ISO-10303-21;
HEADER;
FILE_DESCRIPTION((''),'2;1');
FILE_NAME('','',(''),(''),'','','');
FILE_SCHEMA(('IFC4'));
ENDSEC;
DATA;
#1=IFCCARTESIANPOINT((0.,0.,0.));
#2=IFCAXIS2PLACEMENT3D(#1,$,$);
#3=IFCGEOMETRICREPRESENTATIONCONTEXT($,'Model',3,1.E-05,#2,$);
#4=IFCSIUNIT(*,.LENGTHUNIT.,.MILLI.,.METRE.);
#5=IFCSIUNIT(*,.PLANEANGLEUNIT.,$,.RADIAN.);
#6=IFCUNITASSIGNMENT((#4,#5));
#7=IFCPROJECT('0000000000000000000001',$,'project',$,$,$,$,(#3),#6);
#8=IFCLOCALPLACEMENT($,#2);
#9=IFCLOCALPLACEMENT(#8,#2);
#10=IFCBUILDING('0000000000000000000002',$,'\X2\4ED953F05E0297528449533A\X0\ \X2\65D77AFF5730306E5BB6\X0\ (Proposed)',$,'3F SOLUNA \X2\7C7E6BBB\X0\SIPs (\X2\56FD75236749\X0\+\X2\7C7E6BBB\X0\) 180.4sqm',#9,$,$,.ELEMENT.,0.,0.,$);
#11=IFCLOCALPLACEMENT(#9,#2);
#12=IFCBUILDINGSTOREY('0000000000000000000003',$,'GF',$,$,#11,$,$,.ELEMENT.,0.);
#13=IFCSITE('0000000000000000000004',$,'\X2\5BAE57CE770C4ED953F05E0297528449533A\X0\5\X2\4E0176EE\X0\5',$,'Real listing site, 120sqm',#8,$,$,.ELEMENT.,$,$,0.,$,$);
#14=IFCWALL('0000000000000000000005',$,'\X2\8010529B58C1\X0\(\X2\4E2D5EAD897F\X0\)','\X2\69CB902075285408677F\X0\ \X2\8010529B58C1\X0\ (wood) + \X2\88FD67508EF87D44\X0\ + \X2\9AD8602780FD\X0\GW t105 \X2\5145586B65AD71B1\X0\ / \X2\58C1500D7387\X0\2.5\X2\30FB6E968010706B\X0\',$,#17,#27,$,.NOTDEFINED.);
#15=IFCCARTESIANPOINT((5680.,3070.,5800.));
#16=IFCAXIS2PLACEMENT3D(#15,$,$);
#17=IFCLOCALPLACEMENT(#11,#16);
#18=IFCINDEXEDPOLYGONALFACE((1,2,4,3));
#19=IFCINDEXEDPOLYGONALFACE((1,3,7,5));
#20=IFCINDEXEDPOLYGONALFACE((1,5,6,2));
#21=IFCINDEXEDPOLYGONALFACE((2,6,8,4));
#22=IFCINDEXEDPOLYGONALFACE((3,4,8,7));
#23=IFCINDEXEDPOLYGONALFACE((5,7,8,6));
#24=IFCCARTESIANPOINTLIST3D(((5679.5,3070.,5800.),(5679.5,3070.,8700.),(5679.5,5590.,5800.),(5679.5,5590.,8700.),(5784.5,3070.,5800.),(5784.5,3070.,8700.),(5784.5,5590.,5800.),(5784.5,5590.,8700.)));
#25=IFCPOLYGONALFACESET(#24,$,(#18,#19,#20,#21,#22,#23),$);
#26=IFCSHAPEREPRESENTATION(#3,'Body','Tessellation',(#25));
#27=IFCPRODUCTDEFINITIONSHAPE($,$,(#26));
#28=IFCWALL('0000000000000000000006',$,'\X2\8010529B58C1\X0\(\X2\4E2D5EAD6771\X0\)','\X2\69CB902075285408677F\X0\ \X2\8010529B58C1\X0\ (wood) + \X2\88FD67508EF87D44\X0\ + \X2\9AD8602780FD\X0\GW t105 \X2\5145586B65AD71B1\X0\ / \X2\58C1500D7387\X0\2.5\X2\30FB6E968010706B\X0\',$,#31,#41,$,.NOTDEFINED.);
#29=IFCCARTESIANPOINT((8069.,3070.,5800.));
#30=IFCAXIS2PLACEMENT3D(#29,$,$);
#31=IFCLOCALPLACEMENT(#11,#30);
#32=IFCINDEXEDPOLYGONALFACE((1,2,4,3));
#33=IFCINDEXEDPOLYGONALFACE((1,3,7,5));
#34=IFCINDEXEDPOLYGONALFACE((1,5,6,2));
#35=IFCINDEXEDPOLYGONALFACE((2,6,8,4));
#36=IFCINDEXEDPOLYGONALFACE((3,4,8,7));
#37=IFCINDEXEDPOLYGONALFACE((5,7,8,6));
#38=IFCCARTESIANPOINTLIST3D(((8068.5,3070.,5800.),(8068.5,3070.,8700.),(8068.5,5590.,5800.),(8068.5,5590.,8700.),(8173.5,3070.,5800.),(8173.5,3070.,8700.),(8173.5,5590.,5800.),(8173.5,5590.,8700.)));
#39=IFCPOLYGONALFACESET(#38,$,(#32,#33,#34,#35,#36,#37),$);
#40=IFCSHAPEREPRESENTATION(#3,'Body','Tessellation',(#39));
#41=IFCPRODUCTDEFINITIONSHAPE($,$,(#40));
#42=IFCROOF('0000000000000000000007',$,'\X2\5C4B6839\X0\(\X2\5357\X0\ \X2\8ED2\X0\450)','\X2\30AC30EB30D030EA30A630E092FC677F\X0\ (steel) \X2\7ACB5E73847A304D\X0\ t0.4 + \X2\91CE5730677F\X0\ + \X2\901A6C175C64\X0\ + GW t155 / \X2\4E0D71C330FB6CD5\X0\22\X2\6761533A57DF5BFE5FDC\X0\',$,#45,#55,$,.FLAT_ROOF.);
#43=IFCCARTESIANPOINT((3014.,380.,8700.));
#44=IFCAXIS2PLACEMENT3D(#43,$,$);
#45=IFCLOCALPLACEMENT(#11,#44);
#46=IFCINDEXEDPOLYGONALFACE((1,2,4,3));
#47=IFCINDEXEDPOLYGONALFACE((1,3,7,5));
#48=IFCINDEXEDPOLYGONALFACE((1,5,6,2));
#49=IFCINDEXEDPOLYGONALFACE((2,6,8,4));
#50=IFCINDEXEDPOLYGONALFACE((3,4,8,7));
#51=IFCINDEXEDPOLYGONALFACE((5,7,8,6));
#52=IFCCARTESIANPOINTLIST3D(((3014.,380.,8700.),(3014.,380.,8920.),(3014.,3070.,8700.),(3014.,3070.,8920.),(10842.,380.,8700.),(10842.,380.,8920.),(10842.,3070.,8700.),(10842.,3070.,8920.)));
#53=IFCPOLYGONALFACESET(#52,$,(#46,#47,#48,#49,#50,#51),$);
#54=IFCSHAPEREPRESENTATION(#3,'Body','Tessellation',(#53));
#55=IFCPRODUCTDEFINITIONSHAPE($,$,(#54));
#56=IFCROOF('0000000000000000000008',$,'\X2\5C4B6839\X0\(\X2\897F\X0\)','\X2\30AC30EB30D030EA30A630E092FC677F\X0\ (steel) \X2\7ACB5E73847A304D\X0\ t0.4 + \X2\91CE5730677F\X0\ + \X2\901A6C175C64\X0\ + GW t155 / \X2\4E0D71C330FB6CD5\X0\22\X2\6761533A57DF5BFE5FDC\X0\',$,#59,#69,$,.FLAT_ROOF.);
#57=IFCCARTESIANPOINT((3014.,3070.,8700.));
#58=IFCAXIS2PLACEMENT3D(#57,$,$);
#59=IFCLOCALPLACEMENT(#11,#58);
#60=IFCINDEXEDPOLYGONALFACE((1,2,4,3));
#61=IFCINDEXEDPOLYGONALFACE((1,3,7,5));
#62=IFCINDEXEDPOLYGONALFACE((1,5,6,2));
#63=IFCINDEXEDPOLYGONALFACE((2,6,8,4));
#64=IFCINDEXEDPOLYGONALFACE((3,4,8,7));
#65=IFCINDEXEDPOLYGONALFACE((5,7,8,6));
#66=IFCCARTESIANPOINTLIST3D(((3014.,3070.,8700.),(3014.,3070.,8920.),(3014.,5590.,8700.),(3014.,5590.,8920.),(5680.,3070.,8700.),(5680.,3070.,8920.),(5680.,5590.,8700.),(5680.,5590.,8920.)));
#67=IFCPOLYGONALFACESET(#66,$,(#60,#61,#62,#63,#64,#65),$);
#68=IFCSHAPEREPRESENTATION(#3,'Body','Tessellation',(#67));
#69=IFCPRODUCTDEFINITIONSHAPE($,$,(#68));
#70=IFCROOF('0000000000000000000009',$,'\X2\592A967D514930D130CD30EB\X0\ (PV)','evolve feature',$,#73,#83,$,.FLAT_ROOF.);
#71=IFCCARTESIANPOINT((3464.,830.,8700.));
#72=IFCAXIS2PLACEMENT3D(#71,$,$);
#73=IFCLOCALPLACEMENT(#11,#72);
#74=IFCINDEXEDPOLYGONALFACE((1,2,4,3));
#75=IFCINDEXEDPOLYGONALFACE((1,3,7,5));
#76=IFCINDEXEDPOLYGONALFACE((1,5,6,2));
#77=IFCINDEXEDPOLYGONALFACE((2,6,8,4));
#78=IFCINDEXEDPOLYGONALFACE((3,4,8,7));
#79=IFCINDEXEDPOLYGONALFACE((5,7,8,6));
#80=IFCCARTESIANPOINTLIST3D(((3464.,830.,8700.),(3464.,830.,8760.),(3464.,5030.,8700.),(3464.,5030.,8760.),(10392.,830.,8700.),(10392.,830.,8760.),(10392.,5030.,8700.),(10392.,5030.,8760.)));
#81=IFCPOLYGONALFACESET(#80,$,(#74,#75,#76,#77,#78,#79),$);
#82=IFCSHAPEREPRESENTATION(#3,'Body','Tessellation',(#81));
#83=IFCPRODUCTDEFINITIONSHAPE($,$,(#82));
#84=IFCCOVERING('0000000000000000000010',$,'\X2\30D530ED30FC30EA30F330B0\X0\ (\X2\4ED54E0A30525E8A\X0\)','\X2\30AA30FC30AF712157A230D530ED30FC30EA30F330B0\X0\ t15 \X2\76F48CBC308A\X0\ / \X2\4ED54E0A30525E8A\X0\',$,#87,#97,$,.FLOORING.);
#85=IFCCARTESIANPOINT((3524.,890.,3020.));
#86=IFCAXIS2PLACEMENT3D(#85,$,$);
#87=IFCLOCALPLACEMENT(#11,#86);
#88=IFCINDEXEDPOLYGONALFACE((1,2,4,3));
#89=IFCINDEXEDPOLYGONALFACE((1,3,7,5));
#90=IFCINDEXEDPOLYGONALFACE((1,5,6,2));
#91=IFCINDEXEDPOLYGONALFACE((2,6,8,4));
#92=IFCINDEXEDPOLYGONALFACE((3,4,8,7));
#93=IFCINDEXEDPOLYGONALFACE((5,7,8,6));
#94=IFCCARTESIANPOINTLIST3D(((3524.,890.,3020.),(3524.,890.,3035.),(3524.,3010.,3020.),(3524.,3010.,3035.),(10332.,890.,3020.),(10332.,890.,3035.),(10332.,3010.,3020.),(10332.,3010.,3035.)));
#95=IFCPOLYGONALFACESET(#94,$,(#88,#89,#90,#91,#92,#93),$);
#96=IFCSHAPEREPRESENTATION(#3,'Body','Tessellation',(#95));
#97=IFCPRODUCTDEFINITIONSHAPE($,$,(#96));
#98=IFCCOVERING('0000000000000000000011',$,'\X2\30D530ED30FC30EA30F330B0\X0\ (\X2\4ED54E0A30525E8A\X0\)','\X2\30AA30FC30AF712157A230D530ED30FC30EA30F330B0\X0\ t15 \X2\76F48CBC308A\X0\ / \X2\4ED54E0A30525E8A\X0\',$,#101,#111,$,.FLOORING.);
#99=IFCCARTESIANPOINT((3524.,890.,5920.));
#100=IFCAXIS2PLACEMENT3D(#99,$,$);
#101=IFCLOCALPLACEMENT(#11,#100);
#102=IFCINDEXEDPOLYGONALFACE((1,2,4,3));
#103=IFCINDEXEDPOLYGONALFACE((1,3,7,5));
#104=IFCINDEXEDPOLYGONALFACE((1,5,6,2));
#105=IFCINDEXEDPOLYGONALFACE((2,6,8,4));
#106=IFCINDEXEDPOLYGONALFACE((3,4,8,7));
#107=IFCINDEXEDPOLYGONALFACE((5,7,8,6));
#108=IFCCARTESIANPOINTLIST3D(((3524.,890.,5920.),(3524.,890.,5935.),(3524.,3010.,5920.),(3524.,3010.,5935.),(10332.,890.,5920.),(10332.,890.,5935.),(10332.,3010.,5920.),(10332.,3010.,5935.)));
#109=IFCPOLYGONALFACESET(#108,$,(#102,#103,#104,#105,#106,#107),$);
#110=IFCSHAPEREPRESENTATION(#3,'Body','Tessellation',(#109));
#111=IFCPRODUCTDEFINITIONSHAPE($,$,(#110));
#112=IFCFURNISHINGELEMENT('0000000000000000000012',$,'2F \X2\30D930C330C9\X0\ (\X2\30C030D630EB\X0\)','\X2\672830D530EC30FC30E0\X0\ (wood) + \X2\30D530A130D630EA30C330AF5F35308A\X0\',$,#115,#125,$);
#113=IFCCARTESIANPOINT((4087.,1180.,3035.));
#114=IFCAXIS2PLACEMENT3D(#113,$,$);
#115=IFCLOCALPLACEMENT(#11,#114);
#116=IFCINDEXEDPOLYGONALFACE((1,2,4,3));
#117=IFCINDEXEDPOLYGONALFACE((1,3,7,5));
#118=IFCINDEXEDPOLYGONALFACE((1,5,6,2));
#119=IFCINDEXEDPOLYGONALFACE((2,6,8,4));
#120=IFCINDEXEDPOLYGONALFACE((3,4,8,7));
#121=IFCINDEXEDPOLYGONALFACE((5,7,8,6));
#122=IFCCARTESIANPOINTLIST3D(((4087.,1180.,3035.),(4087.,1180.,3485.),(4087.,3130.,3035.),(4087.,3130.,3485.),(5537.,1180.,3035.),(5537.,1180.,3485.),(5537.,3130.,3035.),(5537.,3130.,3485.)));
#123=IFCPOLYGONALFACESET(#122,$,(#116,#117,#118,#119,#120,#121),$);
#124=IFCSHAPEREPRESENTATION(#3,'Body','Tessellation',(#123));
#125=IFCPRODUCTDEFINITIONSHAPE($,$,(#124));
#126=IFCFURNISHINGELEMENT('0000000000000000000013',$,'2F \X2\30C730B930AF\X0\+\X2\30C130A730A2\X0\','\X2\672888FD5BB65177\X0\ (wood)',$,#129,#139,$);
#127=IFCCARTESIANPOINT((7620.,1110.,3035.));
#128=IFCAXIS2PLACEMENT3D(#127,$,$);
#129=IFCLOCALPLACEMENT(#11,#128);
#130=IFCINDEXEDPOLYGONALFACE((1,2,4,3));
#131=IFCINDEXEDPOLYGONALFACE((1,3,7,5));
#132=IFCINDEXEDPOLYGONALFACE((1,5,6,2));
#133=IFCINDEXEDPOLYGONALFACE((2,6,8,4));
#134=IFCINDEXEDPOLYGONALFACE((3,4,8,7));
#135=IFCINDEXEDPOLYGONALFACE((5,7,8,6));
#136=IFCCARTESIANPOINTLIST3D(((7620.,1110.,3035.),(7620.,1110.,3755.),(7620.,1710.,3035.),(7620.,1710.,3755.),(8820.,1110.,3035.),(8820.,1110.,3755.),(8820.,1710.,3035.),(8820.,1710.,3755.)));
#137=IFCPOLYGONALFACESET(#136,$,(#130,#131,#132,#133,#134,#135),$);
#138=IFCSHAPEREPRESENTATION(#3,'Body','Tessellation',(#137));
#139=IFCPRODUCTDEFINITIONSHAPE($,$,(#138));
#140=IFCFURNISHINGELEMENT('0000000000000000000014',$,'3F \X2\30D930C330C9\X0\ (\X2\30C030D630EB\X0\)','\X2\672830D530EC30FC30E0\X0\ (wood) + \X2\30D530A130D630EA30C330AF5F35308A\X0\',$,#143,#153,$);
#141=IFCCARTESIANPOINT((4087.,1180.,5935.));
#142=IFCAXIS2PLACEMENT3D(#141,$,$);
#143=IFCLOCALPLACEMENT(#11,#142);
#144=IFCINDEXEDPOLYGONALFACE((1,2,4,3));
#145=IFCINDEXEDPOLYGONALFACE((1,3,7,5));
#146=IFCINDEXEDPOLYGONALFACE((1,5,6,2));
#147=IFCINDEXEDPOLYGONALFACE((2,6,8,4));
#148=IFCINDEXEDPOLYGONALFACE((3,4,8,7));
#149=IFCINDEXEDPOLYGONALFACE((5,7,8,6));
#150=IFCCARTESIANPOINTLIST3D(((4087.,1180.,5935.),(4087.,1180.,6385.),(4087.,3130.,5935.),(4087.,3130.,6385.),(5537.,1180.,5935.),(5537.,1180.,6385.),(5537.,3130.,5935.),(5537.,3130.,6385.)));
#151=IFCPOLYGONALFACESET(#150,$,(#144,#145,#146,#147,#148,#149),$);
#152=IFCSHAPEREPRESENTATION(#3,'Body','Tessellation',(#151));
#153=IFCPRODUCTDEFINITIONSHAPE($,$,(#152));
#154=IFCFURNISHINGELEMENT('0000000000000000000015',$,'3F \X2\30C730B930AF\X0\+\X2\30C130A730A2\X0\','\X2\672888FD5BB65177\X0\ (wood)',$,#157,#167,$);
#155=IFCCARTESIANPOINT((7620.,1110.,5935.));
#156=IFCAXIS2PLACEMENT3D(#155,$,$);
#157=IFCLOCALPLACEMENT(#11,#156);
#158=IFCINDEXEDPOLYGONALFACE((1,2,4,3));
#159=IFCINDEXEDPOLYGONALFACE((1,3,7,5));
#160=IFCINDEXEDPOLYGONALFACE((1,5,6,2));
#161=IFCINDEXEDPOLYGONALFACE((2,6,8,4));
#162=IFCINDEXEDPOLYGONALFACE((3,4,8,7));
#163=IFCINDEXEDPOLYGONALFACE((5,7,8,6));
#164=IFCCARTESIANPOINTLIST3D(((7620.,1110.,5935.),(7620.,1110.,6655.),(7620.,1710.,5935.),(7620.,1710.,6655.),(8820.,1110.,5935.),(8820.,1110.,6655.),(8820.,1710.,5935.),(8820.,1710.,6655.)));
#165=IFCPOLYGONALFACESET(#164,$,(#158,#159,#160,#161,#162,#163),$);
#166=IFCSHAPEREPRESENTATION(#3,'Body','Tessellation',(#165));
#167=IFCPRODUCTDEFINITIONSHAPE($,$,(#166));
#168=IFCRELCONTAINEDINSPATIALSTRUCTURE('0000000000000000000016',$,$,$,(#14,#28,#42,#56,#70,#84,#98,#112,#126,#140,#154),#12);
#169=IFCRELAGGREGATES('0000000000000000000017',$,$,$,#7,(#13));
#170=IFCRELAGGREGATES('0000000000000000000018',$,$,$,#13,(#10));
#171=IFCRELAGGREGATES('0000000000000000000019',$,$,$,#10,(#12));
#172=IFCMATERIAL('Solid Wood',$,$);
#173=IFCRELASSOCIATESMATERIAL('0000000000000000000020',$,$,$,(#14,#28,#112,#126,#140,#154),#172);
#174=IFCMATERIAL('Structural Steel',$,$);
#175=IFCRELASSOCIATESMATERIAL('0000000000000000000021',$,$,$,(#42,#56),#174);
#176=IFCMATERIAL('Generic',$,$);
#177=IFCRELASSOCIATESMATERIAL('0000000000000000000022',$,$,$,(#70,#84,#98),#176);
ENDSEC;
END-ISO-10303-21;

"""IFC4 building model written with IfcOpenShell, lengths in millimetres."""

from ifc_helpers import new_model, si_unit, frame, frame_2d, origin, place, context, project, spatial, rectangle, extrude, material, element, save


model = new_model("IFC4")

# Units and contexts
model_context = context("Model", 3, precision=1e-05, world=origin())
ifc_project = project(units=[si_unit("LENGTHUNIT", "METRE", prefix="MILLI"), si_unit("PLANEANGLEUNIT", "RADIAN")], contexts=[model_context])

# Site, building, storey
site_placement = place(None, origin())
site = spatial("IfcSite", under=ifc_project, at=site_placement, Name="宮城県仙台市青葉区5丁目5", ObjectType="Real listing site, 120sqm", CompositionType="ELEMENT", RefElevation=0.0)
building_placement = place(site_placement, origin())
building = spatial("IfcBuilding", under=site, at=building_placement, Name="仙台市青葉区 旗竿地の家 (Proposed)", ObjectType="3F SOLUNA 籾殻SIPs (国産杉+籾殻) 180.4sqm", CompositionType="ELEMENT", ElevationOfRefHeight=0.0, ElevationOfTerrain=0.0)
storey_placement = place(building_placement, origin())
storey = spatial("IfcBuildingStorey", under=building, at=storey_placement, Name="GF", CompositionType="ELEMENT", Elevation=0.0)

# Shared definitions
ifc_material_1 = material(Name="Solid Wood")

# Walls
wall_1_placement = place(storey_placement, frame((5680.0, 3070.0, 5800.0)))
element("IfcWall", 1, at=wall_1_placement, inside=storey, material=ifc_material_1, Name="耐力壁(中庭西)", Description="構造用合板 耐力壁 (wood) + 製材軸組 + 高性能GW t105 充填断熱 / 壁倍率2.5・準耐火", PredefinedType="NOTDEFINED", context=model_context, shape_type="SweptSolid", body=[
    extrude(rectangle(XDim=105.0, YDim=2520.0, at=frame_2d((52.0, 1260.0))), frame((5680.0, 3070.0, 5800.0)), (0.0, 0.0, 1.0), 2900.0),
])
wall_2_placement = place(storey_placement, frame((8069.0, 3070.0, 5800.0)))
element("IfcWall", 2, at=wall_2_placement, inside=storey, material=ifc_material_1, Name="耐力壁(中庭東)", Description="構造用合板 耐力壁 (wood) + 製材軸組 + 高性能GW t105 充填断熱 / 壁倍率2.5・準耐火", PredefinedType="NOTDEFINED", context=model_context, shape_type="SweptSolid", body=[
    extrude(rectangle(XDim=105.0, YDim=2520.0, at=frame_2d((52.0, 1260.0))), frame((8069.0, 3070.0, 5800.0)), (0.0, 0.0, 1.0), 2900.0),
])

# Roofs
ifc_material_2 = material(Name="Structural Steel")
roof_1_placement = place(storey_placement, frame((3014.0, 380.0, 8700.0)))
element("IfcRoof", 3, at=roof_1_placement, inside=storey, material=ifc_material_2, Name="屋根(南 軒450)", Description="ガルバリウム鋼板 (steel) 立平葺き t0.4 + 野地板 + 通気層 + GW t155 / 不燃・法22条区域対応", PredefinedType="FLAT_ROOF", context=model_context, shape_type="SweptSolid", body=[
    extrude(rectangle(XDim=7828.0, YDim=2690.0, at=frame_2d((3914.0, 1345.0))), frame((3014.0, 380.0, 8700.0)), (0.0, 0.0, 1.0), 220.0),
])
roof_2_placement = place(storey_placement, frame((3014.0, 3070.0, 8700.0)))
element("IfcRoof", 4, at=roof_2_placement, inside=storey, material=ifc_material_2, Name="屋根(西)", Description="ガルバリウム鋼板 (steel) 立平葺き t0.4 + 野地板 + 通気層 + GW t155 / 不燃・法22条区域対応", PredefinedType="FLAT_ROOF", context=model_context, shape_type="SweptSolid", body=[
    extrude(rectangle(XDim=2666.0, YDim=2520.0, at=frame_2d((1333.0, 1260.0))), frame((3014.0, 3070.0, 8700.0)), (0.0, 0.0, 1.0), 220.0),
])
ifc_material_3 = material(Name="Generic")
roof_3_placement = place(storey_placement, frame((3464.0, 830.0, 8700.0)))
element("IfcRoof", 5, at=roof_3_placement, inside=storey, material=ifc_material_3, Name="太陽光パネル (PV)", Description="evolve feature", PredefinedType="FLAT_ROOF", context=model_context, shape_type="SweptSolid", body=[
    extrude(rectangle(XDim=6928.0, YDim=4200.0, at=frame_2d((3464.0, 2100.0))), frame((3464.0, 830.0, 8700.0)), (0.0, 0.0, 1.0), 60.0),
])

# Coverings
covering_1_placement = place(storey_placement, frame((3524.0, 890.0, 3020.0)))
element("IfcCovering", 6, at=covering_1_placement, inside=storey, material=ifc_material_3, Name="フローリング (仕上げ床)", Description="オーク無垢フローリング t15 直貼り / 仕上げ床", PredefinedType="FLOORING", context=model_context, shape_type="SweptSolid", body=[
    extrude(rectangle(XDim=6808.0, YDim=2120.0, at=frame_2d((3404.0, 1060.0))), frame((3524.0, 890.0, 3020.0)), (0.0, 0.0, 1.0), 15.0),
])
covering_2_placement = place(storey_placement, frame((3524.0, 890.0, 5920.0)))
element("IfcCovering", 7, at=covering_2_placement, inside=storey, material=ifc_material_3, Name="フローリング (仕上げ床)", Description="オーク無垢フローリング t15 直貼り / 仕上げ床", PredefinedType="FLOORING", context=model_context, shape_type="SweptSolid", body=[
    extrude(rectangle(XDim=6808.0, YDim=2120.0, at=frame_2d((3404.0, 1060.0))), frame((3524.0, 890.0, 5920.0)), (0.0, 0.0, 1.0), 15.0),
])

# Furnishing elements
furnishing_1_placement = place(storey_placement, frame((4087.0, 1180.0, 3035.0)))
element("IfcFurnishingElement", 8, at=furnishing_1_placement, inside=storey, material=ifc_material_1, Name="2F ベッド (ダブル)", Description="木フレーム (wood) + ファブリック張り", context=model_context, shape_type="SweptSolid", body=[
    extrude(rectangle(XDim=1450.0, YDim=1950.0, at=frame_2d((725.0, 975.0))), frame((4087.0, 1180.0, 3035.0)), (0.0, 0.0, 1.0), 450.0),
])
furnishing_2_placement = place(storey_placement, frame((7620.0, 1110.0, 3035.0)))
element("IfcFurnishingElement", 9, at=furnishing_2_placement, inside=storey, material=ifc_material_1, Name="2F デスク+チェア", Description="木製家具 (wood)", context=model_context, shape_type="SweptSolid", body=[
    extrude(rectangle(XDim=1200.0, YDim=600.0, at=frame_2d((600.0, 300.0))), frame((7620.0, 1110.0, 3035.0)), (0.0, 0.0, 1.0), 720.0),
])
furnishing_3_placement = place(storey_placement, frame((4087.0, 1180.0, 5935.0)))
element("IfcFurnishingElement", 10, at=furnishing_3_placement, inside=storey, material=ifc_material_1, Name="3F ベッド (ダブル)", Description="木フレーム (wood) + ファブリック張り", context=model_context, shape_type="SweptSolid", body=[
    extrude(rectangle(XDim=1450.0, YDim=1950.0, at=frame_2d((725.0, 975.0))), frame((4087.0, 1180.0, 5935.0)), (0.0, 0.0, 1.0), 450.0),
])
furnishing_4_placement = place(storey_placement, frame((7620.0, 1110.0, 5935.0)))
element("IfcFurnishingElement", 11, at=furnishing_4_placement, inside=storey, material=ifc_material_1, Name="3F デスク+チェア", Description="木製家具 (wood)", context=model_context, shape_type="SweptSolid", body=[
    extrude(rectangle(XDim=1200.0, YDim=600.0, at=frame_2d((600.0, 300.0))), frame((7620.0, 1110.0, 5935.0)), (0.0, 0.0, 1.0), 720.0),
])

save(model, "model.ifc")
